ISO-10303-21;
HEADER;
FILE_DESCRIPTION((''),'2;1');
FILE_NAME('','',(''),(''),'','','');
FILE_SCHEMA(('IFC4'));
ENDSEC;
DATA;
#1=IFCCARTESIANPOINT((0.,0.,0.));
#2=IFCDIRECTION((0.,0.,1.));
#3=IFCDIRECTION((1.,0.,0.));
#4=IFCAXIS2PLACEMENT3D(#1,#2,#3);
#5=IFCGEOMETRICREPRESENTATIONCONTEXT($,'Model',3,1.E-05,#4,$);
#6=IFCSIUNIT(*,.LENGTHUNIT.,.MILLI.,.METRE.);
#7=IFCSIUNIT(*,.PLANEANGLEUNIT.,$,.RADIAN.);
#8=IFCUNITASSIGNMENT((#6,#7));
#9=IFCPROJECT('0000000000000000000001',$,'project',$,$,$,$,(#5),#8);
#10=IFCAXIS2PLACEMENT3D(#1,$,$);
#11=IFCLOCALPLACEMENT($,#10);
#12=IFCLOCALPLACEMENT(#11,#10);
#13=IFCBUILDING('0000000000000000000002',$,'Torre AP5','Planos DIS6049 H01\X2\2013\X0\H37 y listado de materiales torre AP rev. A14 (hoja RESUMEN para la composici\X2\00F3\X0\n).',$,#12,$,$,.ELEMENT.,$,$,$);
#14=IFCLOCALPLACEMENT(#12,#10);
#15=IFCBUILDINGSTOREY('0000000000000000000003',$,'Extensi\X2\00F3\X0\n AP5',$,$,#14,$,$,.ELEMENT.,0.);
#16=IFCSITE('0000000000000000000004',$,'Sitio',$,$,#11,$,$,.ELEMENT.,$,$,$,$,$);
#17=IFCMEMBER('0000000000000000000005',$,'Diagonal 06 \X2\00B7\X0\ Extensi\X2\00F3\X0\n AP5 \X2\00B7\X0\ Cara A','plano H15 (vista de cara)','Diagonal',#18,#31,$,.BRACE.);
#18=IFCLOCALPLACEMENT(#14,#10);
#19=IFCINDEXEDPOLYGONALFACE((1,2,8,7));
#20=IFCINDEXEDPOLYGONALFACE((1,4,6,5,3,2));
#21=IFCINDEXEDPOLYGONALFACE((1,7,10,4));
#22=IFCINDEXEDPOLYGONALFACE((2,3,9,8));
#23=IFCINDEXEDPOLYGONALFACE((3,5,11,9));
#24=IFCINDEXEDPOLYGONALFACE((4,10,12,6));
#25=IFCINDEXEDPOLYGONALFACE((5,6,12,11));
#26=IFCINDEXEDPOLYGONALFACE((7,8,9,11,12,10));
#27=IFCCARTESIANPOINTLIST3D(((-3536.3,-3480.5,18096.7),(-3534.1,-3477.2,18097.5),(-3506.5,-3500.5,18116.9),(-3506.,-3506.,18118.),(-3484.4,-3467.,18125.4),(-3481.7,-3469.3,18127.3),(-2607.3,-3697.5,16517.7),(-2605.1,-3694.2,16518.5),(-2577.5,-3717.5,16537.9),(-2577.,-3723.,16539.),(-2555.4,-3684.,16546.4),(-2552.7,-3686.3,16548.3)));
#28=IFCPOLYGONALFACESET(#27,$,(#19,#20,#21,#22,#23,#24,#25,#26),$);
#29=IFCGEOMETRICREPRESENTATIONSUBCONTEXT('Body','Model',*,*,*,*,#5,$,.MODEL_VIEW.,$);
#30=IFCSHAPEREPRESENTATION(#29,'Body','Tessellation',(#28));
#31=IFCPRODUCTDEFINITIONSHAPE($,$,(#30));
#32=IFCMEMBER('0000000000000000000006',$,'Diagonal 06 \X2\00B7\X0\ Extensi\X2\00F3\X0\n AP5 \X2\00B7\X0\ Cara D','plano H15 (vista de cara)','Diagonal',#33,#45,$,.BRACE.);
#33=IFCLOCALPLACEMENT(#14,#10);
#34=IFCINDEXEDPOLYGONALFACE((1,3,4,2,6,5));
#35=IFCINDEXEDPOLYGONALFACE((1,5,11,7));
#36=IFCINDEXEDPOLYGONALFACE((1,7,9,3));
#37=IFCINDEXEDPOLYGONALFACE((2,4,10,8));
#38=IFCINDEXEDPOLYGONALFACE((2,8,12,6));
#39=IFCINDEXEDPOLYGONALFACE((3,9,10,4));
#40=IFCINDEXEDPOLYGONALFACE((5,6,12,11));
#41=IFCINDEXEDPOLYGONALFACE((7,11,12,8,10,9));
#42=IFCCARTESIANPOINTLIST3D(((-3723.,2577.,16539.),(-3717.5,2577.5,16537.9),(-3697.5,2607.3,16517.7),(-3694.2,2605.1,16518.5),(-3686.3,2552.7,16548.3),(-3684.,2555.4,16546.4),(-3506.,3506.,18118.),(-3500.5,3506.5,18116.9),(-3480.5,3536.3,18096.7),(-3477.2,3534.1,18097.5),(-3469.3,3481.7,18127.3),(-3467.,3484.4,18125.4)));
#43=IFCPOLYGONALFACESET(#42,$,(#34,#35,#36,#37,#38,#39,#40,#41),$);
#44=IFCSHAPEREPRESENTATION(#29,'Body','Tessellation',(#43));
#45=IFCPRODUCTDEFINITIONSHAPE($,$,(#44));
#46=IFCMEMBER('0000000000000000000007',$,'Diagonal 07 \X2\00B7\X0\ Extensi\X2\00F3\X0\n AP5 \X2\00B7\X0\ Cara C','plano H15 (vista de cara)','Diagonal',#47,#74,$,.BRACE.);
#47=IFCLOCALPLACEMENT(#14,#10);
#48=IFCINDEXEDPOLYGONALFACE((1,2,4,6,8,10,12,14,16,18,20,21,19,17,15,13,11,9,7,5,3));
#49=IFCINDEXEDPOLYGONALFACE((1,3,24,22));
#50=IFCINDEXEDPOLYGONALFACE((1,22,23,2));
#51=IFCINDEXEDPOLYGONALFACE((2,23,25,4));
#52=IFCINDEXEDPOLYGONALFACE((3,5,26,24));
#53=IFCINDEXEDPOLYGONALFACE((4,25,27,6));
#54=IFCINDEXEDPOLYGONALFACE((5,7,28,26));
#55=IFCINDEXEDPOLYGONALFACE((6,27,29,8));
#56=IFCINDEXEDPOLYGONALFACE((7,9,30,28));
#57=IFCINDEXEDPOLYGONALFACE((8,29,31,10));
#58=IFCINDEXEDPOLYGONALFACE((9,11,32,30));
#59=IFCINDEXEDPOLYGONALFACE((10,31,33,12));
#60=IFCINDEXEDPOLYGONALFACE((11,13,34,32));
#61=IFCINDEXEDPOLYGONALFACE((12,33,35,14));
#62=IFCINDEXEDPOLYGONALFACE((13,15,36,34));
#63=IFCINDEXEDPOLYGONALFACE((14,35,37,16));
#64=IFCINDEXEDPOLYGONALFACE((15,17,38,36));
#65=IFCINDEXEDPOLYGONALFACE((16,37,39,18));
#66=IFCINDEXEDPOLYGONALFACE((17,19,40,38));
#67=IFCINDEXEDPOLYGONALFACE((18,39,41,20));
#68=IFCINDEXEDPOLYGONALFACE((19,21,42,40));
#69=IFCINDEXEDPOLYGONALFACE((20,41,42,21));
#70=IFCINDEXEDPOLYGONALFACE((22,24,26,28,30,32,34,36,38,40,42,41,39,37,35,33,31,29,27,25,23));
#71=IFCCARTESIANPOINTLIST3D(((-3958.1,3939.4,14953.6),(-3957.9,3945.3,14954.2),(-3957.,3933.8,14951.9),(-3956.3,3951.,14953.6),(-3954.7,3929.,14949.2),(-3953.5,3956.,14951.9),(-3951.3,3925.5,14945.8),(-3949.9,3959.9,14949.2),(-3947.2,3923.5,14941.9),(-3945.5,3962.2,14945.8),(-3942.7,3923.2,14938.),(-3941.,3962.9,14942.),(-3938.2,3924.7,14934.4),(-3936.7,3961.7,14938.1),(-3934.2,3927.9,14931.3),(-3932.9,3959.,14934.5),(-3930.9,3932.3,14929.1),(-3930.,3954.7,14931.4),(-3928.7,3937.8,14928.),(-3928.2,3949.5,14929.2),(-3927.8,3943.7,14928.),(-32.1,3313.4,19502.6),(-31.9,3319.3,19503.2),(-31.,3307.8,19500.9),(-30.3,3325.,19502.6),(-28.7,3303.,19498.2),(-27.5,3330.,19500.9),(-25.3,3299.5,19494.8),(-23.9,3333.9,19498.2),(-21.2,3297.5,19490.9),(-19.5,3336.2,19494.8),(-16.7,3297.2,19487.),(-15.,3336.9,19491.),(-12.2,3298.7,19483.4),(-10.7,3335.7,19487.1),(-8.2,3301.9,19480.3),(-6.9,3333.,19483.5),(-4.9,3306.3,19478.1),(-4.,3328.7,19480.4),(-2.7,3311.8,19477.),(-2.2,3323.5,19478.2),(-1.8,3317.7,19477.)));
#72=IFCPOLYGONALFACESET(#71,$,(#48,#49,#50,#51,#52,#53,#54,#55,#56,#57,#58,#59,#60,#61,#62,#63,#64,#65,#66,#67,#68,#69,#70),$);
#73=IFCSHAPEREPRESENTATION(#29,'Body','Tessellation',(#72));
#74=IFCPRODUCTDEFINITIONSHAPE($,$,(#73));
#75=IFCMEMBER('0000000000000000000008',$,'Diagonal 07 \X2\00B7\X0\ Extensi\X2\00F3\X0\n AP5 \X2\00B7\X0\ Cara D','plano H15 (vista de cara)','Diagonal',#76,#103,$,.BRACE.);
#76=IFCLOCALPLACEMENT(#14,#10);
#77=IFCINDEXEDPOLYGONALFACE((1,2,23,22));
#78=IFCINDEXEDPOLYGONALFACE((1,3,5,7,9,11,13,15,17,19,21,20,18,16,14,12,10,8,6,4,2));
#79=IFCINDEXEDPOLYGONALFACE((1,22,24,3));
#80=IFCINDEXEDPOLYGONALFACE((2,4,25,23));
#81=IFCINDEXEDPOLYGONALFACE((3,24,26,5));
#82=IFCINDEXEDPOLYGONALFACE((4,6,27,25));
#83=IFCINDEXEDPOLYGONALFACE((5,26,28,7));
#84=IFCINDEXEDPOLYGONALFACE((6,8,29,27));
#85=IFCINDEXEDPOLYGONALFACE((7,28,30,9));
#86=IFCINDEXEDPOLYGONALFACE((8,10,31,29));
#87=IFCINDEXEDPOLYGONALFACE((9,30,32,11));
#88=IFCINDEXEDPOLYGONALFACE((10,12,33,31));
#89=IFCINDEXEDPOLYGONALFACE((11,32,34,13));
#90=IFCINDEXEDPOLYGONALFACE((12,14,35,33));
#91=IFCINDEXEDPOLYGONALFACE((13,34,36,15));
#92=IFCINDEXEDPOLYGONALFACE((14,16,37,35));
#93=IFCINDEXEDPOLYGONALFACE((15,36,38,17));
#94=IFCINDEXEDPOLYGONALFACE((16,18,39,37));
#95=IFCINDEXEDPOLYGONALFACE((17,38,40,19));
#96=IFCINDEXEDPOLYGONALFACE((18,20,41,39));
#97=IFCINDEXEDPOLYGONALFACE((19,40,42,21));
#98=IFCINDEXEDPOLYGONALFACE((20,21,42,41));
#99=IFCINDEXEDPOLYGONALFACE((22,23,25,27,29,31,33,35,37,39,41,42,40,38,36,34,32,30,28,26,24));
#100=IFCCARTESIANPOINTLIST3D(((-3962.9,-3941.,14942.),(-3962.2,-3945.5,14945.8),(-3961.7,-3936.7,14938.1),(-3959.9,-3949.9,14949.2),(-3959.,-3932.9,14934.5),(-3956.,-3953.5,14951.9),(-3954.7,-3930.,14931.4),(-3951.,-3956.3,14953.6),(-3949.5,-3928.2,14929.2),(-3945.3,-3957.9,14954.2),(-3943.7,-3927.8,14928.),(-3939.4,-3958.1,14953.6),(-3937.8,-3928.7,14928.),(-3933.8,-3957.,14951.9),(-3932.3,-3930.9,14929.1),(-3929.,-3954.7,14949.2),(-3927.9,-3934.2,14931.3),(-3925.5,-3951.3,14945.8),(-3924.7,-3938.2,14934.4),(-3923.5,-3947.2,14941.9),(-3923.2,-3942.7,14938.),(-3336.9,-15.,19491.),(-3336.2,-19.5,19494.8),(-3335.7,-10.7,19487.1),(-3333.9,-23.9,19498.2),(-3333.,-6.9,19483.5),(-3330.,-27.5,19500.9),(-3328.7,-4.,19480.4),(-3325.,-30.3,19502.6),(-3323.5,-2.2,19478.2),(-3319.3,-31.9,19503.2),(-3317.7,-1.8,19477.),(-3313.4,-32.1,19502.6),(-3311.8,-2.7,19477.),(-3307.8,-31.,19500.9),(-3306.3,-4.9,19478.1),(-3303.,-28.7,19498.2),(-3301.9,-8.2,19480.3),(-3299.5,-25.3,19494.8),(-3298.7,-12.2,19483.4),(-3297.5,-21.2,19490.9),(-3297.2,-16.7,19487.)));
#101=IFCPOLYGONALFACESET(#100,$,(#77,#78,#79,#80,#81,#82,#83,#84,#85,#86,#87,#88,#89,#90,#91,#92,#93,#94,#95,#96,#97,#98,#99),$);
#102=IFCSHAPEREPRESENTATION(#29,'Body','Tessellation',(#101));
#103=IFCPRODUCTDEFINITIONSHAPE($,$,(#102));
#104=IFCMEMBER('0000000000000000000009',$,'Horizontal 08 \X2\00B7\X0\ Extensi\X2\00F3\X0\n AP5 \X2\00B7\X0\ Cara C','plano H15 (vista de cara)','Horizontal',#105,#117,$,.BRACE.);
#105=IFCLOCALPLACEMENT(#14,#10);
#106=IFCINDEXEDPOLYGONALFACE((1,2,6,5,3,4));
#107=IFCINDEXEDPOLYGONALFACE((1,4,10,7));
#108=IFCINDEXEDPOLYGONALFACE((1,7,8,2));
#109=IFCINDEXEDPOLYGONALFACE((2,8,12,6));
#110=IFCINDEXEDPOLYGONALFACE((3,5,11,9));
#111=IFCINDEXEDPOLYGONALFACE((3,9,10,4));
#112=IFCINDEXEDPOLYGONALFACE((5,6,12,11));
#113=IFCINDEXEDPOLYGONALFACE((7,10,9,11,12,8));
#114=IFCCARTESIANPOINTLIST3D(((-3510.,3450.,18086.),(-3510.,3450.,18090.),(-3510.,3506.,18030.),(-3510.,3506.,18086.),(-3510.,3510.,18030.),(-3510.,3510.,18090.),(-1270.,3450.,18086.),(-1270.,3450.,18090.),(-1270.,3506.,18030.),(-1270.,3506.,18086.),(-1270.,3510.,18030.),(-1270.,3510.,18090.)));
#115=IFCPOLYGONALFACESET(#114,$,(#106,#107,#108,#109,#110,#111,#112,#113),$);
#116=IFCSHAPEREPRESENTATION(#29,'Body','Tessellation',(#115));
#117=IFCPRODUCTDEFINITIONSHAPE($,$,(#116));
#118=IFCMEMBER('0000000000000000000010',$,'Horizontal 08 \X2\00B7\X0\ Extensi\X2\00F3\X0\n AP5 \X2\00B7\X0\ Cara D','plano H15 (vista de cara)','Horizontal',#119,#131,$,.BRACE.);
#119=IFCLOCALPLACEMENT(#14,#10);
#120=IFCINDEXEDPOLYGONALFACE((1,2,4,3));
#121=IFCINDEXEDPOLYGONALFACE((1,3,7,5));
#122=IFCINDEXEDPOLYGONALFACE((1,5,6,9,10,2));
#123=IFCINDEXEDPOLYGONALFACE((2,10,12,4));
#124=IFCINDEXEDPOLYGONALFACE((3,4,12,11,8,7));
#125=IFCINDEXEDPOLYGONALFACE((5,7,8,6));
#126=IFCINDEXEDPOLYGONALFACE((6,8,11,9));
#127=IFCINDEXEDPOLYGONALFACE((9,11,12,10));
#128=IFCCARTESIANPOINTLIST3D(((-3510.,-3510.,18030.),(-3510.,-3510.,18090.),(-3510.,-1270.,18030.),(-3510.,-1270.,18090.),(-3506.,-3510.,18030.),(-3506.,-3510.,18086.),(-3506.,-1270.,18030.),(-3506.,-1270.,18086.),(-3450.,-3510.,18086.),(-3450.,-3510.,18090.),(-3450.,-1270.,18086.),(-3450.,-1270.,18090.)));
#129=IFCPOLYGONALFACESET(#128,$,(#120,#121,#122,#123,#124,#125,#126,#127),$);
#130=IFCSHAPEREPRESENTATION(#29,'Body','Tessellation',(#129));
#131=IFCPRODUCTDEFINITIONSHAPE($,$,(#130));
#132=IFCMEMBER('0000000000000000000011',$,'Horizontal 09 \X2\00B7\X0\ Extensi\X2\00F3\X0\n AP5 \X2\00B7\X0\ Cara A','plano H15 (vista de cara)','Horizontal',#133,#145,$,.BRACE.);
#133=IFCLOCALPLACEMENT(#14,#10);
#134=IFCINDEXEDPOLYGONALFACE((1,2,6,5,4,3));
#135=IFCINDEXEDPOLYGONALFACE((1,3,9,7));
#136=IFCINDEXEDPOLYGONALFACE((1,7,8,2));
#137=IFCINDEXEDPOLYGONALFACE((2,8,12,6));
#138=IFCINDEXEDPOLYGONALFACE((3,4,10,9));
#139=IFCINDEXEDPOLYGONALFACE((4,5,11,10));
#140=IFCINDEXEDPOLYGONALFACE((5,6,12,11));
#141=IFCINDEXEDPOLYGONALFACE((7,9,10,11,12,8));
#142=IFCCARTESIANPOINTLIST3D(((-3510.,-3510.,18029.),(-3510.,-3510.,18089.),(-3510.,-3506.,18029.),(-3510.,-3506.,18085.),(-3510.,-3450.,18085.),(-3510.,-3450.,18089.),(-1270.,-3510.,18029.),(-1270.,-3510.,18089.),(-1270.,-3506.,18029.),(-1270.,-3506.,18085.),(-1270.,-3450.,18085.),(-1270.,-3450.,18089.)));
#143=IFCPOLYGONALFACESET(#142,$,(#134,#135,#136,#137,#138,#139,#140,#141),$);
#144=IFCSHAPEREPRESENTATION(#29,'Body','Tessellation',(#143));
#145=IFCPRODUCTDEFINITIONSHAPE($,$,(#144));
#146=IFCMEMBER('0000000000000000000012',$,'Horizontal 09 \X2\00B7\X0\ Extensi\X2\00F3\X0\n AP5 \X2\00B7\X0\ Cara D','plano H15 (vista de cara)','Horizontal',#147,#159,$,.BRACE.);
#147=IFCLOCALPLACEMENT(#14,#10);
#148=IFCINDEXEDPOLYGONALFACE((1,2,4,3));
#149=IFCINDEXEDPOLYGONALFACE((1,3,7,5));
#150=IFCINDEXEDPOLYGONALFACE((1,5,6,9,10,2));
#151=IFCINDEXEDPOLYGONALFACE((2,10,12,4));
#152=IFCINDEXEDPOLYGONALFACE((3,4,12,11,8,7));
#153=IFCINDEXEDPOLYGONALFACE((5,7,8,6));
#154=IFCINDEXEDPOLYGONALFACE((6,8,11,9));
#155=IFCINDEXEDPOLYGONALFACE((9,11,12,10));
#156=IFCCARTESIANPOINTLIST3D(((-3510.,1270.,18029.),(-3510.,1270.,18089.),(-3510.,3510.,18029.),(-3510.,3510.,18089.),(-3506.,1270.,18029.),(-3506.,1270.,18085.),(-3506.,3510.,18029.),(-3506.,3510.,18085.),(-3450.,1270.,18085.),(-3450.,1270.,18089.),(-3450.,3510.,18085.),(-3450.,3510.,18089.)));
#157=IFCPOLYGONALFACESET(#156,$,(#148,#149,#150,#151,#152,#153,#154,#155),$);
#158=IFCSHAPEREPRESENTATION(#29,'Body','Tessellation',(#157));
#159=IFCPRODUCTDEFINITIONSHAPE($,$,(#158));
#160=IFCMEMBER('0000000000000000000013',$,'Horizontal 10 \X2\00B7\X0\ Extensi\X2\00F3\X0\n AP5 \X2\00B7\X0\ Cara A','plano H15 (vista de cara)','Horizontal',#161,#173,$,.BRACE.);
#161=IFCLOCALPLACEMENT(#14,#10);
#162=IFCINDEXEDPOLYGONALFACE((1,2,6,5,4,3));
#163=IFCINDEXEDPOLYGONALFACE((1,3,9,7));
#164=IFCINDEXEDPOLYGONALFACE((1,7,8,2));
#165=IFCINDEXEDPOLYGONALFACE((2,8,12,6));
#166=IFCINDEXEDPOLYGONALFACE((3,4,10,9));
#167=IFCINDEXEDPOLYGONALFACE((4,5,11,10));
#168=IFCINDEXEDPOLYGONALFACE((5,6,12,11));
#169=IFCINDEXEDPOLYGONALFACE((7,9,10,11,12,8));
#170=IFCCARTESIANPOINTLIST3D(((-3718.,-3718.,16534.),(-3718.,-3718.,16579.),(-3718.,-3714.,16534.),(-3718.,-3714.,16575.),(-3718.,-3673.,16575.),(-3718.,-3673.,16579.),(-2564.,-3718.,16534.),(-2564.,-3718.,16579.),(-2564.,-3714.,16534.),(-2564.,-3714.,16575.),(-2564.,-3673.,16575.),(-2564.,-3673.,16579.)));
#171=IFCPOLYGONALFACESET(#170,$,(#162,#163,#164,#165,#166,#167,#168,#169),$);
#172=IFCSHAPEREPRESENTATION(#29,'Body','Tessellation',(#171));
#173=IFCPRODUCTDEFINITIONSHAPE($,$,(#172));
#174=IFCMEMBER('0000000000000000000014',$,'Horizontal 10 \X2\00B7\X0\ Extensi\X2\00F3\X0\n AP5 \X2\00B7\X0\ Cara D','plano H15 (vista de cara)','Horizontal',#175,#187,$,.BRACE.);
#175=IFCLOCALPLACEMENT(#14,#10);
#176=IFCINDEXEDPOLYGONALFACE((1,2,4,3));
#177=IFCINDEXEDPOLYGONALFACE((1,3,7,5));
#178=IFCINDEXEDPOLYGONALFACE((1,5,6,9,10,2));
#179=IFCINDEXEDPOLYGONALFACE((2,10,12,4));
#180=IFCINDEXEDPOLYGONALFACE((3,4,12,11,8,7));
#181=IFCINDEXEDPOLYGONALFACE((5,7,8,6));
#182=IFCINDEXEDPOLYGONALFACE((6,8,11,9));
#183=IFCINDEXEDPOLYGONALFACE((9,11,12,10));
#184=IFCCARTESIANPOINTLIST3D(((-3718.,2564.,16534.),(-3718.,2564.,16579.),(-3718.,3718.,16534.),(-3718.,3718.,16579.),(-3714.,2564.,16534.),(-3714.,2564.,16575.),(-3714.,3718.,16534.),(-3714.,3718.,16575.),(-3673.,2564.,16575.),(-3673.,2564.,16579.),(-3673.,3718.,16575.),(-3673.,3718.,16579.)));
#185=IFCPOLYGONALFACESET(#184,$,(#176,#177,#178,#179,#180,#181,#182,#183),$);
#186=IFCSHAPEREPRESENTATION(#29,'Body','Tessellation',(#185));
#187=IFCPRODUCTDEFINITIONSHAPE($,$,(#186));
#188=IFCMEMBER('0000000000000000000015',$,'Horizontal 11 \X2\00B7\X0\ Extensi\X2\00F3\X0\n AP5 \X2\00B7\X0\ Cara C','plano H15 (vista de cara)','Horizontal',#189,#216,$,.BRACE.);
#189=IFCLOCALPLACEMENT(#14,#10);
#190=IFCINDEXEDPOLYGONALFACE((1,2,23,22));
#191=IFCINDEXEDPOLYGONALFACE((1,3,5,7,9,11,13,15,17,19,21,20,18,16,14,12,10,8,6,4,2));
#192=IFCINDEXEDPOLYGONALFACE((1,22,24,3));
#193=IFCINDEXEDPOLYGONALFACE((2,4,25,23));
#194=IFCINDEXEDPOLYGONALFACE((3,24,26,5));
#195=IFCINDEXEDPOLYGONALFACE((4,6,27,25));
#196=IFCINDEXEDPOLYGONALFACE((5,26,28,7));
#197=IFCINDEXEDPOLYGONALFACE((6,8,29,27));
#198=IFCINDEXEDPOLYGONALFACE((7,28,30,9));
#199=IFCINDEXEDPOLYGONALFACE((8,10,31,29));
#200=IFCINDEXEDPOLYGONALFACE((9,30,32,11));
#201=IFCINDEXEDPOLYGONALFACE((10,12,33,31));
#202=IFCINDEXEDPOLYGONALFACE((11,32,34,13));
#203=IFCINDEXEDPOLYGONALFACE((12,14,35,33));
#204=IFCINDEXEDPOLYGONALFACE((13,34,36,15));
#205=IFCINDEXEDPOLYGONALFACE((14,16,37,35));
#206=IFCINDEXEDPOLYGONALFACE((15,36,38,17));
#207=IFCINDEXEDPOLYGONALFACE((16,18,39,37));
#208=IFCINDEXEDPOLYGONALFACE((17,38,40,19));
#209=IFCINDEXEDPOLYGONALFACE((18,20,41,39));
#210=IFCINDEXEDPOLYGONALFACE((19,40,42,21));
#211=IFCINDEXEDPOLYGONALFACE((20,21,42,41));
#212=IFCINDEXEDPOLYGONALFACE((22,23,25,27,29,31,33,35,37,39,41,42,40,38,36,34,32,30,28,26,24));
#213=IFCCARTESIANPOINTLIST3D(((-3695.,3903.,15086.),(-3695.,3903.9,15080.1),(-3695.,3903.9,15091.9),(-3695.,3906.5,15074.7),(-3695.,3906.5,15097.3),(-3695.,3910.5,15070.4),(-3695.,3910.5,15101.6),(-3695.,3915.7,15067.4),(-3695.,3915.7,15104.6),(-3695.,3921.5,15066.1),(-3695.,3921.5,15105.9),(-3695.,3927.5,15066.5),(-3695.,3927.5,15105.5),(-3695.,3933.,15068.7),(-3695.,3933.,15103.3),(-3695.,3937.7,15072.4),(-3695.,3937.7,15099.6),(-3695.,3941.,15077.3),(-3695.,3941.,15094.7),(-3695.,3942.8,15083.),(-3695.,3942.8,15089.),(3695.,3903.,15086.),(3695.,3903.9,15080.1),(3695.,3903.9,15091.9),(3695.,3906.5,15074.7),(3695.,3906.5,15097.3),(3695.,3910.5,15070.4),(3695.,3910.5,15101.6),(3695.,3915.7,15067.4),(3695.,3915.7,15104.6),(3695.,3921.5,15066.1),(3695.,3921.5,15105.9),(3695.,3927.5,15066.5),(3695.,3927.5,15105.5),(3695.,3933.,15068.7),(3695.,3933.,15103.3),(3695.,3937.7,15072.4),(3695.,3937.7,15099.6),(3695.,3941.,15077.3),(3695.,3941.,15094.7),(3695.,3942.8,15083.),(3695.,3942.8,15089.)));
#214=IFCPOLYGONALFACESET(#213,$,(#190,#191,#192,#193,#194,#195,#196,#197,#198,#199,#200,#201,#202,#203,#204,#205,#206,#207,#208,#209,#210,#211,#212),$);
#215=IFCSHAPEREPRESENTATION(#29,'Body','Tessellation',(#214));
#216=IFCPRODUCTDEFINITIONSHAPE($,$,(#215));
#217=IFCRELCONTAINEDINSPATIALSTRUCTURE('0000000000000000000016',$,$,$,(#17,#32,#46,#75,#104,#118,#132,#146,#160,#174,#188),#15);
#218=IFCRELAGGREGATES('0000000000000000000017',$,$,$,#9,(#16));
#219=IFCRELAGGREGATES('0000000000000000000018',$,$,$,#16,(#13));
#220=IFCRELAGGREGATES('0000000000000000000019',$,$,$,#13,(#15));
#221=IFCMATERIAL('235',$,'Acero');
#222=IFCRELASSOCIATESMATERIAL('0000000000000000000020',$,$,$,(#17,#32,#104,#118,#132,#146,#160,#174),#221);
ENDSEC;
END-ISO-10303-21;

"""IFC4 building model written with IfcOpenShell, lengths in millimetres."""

from ifc_helpers import new_model, si_unit, frame, frame_2d, origin, origin_with_axes, place, context, subcontext, project, spatial, circle, l_section, extrude, material, element, save


model = new_model("IFC4")

# Units and contexts
model_context = context("Model", 3, precision=1e-05, world=origin_with_axes())
body_context = subcontext(model_context, "Body", "Model", "MODEL_VIEW")
ifc_project = project(units=[si_unit("LENGTHUNIT", "METRE", prefix="MILLI"), si_unit("PLANEANGLEUNIT", "RADIAN")], contexts=[model_context])

# Site, building, storey
site_placement = place(None, origin())
site = spatial("IfcSite", under=ifc_project, at=site_placement, Name="Sitio", CompositionType="ELEMENT")
building_placement = place(site_placement, origin())
building = spatial("IfcBuilding", under=site, at=building_placement, Name="Torre AP5", Description="Planos DIS6049 H01–H37 y listado de materiales torre AP rev. A14 (hoja RESUMEN para la composición).", CompositionType="ELEMENT")
storey_placement = place(building_placement, origin())
storey = spatial("IfcBuildingStorey", under=building, at=storey_placement, Name="Extensión AP5", CompositionType="ELEMENT", Elevation=0.0)

# Members
ifc_material_1 = material(Name="235", Category="Acero")
for number, where, z_axis, x_axis, name in (
    (1, (-2577.0, -3723.0, 16539.0), (-0.503571, 0.117626, 0.855909), (0.540952, 0.815383, 0.20621), "Diagonal 06 · Extensión AP5 · Cara A"),
    (2, (-3723.0, 2577.0, 16539.0), (0.117626, 0.503571, 0.855909), (0.815383, -0.540952, 0.20621), "Diagonal 06 · Extensión AP5 · Cara D"),
):
    element("IfcMember", number, at=place(storey_placement, frame(where, z_axis=z_axis, x_axis=x_axis)), inside=storey, material=ifc_material_1, Name=name, Description="plano H15 (vista de cara)", ObjectType="Diagonal", PredefinedType="BRACE", context=body_context, shape_type="SweptSolid", body=[
        extrude(l_section(Depth=45.0, Width=45.0, Thickness=4.0, at=frame_2d((22.5, 22.5))), None, (0.0, 0.0, 1.0), 1844.8),
    ])
for number, where, z_axis, x_axis, name in (
    (3, (-3943.0, 3943.0, 14941.0), (0.649847, -0.103618, 0.752969), (0.237576, -0.913334, -0.330725), "Diagonal 07 · Extensión AP5 · Cara C"),
    (4, (-3943.0, -3943.0, 14941.0), (0.103618, 0.649847, 0.752969), (0.913334, 0.237576, -0.330725), "Diagonal 07 · Extensión AP5 · Cara D"),
):
    element("IfcMember", number, at=place(storey_placement, frame(where, z_axis=z_axis, x_axis=x_axis)), inside=storey, Name=name, Description="plano H15 (vista de cara)", ObjectType="Diagonal", PredefinedType="BRACE", context=body_context, shape_type="SweptSolid", body=[
        extrude(circle(Radius=20.0), None, (0.0, 0.0, 1.0), 6041.4),
    ])
for number, where, z_axis, x_axis, name in (
    (5, (-3510.0, 3510.0, 18090.0), (1.0, 0.0, 0.0), (0.0, -1.0, 0.0), "Horizontal 08 · Extensión AP5 · Cara C"),
    (6, (-3510.0, -3510.0, 18090.0), (0.0, 1.0, 0.0), (1.0, 0.0, 0.0), "Horizontal 08 · Extensión AP5 · Cara D"),
    (7, (-1270.0, -3510.0, 18089.0), (-1.0, 0.0, 0.0), (0.0, 1.0, 0.0), "Horizontal 09 · Extensión AP5 · Cara A"),
    (8, (-3510.0, 1270.0, 18089.0), (0.0, 1.0, 0.0), (1.0, 0.0, 0.0), "Horizontal 09 · Extensión AP5 · Cara D"),
):
    element("IfcMember", number, at=place(storey_placement, frame(where, z_axis=z_axis, x_axis=x_axis)), inside=storey, material=ifc_material_1, Name=name, Description="plano H15 (vista de cara)", ObjectType="Horizontal", PredefinedType="BRACE", context=body_context, shape_type="SweptSolid", body=[
        extrude(l_section(Depth=60.0, Width=60.0, Thickness=4.0, at=frame_2d((30.0, 30.0))), None, (0.0, 0.0, 1.0), 2240.0),
    ])
for number, where, z_axis, x_axis, name in (
    (9, (-2564.0, -3718.0, 16579.0), (-1.0, 0.0, 0.0), (0.0, 1.0, 0.0), "Horizontal 10 · Extensión AP5 · Cara A"),
    (10, (-3718.0, 2564.0, 16579.0), (0.0, 1.0, 0.0), (1.0, 0.0, 0.0), "Horizontal 10 · Extensión AP5 · Cara D"),
):
    element("IfcMember", number, at=place(storey_placement, frame(where, z_axis=z_axis, x_axis=x_axis)), inside=storey, material=ifc_material_1, Name=name, Description="plano H15 (vista de cara)", ObjectType="Horizontal", PredefinedType="BRACE", context=body_context, shape_type="SweptSolid", body=[
        extrude(l_section(Depth=45.0, Width=45.0, Thickness=4.0, at=frame_2d((22.5, 22.5))), None, (0.0, 0.0, 1.0), 1154.0),
    ])
for number, where, z_axis, x_axis, name in (
    (11, (-3695.0, 3923.0, 15086.0), (1.0, 0.0, 0.0), (0.0, -1.0, 0.0), "Horizontal 11 · Extensión AP5 · Cara C"),
):
    element("IfcMember", number, at=place(storey_placement, frame(where, z_axis=z_axis, x_axis=x_axis)), inside=storey, Name=name, Description="plano H15 (vista de cara)", ObjectType="Horizontal", PredefinedType="BRACE", context=body_context, shape_type="SweptSolid", body=[
        extrude(circle(Radius=20.0), None, (0.0, 0.0, 1.0), 7390.0),
    ])

save(model, "model.ifc")
